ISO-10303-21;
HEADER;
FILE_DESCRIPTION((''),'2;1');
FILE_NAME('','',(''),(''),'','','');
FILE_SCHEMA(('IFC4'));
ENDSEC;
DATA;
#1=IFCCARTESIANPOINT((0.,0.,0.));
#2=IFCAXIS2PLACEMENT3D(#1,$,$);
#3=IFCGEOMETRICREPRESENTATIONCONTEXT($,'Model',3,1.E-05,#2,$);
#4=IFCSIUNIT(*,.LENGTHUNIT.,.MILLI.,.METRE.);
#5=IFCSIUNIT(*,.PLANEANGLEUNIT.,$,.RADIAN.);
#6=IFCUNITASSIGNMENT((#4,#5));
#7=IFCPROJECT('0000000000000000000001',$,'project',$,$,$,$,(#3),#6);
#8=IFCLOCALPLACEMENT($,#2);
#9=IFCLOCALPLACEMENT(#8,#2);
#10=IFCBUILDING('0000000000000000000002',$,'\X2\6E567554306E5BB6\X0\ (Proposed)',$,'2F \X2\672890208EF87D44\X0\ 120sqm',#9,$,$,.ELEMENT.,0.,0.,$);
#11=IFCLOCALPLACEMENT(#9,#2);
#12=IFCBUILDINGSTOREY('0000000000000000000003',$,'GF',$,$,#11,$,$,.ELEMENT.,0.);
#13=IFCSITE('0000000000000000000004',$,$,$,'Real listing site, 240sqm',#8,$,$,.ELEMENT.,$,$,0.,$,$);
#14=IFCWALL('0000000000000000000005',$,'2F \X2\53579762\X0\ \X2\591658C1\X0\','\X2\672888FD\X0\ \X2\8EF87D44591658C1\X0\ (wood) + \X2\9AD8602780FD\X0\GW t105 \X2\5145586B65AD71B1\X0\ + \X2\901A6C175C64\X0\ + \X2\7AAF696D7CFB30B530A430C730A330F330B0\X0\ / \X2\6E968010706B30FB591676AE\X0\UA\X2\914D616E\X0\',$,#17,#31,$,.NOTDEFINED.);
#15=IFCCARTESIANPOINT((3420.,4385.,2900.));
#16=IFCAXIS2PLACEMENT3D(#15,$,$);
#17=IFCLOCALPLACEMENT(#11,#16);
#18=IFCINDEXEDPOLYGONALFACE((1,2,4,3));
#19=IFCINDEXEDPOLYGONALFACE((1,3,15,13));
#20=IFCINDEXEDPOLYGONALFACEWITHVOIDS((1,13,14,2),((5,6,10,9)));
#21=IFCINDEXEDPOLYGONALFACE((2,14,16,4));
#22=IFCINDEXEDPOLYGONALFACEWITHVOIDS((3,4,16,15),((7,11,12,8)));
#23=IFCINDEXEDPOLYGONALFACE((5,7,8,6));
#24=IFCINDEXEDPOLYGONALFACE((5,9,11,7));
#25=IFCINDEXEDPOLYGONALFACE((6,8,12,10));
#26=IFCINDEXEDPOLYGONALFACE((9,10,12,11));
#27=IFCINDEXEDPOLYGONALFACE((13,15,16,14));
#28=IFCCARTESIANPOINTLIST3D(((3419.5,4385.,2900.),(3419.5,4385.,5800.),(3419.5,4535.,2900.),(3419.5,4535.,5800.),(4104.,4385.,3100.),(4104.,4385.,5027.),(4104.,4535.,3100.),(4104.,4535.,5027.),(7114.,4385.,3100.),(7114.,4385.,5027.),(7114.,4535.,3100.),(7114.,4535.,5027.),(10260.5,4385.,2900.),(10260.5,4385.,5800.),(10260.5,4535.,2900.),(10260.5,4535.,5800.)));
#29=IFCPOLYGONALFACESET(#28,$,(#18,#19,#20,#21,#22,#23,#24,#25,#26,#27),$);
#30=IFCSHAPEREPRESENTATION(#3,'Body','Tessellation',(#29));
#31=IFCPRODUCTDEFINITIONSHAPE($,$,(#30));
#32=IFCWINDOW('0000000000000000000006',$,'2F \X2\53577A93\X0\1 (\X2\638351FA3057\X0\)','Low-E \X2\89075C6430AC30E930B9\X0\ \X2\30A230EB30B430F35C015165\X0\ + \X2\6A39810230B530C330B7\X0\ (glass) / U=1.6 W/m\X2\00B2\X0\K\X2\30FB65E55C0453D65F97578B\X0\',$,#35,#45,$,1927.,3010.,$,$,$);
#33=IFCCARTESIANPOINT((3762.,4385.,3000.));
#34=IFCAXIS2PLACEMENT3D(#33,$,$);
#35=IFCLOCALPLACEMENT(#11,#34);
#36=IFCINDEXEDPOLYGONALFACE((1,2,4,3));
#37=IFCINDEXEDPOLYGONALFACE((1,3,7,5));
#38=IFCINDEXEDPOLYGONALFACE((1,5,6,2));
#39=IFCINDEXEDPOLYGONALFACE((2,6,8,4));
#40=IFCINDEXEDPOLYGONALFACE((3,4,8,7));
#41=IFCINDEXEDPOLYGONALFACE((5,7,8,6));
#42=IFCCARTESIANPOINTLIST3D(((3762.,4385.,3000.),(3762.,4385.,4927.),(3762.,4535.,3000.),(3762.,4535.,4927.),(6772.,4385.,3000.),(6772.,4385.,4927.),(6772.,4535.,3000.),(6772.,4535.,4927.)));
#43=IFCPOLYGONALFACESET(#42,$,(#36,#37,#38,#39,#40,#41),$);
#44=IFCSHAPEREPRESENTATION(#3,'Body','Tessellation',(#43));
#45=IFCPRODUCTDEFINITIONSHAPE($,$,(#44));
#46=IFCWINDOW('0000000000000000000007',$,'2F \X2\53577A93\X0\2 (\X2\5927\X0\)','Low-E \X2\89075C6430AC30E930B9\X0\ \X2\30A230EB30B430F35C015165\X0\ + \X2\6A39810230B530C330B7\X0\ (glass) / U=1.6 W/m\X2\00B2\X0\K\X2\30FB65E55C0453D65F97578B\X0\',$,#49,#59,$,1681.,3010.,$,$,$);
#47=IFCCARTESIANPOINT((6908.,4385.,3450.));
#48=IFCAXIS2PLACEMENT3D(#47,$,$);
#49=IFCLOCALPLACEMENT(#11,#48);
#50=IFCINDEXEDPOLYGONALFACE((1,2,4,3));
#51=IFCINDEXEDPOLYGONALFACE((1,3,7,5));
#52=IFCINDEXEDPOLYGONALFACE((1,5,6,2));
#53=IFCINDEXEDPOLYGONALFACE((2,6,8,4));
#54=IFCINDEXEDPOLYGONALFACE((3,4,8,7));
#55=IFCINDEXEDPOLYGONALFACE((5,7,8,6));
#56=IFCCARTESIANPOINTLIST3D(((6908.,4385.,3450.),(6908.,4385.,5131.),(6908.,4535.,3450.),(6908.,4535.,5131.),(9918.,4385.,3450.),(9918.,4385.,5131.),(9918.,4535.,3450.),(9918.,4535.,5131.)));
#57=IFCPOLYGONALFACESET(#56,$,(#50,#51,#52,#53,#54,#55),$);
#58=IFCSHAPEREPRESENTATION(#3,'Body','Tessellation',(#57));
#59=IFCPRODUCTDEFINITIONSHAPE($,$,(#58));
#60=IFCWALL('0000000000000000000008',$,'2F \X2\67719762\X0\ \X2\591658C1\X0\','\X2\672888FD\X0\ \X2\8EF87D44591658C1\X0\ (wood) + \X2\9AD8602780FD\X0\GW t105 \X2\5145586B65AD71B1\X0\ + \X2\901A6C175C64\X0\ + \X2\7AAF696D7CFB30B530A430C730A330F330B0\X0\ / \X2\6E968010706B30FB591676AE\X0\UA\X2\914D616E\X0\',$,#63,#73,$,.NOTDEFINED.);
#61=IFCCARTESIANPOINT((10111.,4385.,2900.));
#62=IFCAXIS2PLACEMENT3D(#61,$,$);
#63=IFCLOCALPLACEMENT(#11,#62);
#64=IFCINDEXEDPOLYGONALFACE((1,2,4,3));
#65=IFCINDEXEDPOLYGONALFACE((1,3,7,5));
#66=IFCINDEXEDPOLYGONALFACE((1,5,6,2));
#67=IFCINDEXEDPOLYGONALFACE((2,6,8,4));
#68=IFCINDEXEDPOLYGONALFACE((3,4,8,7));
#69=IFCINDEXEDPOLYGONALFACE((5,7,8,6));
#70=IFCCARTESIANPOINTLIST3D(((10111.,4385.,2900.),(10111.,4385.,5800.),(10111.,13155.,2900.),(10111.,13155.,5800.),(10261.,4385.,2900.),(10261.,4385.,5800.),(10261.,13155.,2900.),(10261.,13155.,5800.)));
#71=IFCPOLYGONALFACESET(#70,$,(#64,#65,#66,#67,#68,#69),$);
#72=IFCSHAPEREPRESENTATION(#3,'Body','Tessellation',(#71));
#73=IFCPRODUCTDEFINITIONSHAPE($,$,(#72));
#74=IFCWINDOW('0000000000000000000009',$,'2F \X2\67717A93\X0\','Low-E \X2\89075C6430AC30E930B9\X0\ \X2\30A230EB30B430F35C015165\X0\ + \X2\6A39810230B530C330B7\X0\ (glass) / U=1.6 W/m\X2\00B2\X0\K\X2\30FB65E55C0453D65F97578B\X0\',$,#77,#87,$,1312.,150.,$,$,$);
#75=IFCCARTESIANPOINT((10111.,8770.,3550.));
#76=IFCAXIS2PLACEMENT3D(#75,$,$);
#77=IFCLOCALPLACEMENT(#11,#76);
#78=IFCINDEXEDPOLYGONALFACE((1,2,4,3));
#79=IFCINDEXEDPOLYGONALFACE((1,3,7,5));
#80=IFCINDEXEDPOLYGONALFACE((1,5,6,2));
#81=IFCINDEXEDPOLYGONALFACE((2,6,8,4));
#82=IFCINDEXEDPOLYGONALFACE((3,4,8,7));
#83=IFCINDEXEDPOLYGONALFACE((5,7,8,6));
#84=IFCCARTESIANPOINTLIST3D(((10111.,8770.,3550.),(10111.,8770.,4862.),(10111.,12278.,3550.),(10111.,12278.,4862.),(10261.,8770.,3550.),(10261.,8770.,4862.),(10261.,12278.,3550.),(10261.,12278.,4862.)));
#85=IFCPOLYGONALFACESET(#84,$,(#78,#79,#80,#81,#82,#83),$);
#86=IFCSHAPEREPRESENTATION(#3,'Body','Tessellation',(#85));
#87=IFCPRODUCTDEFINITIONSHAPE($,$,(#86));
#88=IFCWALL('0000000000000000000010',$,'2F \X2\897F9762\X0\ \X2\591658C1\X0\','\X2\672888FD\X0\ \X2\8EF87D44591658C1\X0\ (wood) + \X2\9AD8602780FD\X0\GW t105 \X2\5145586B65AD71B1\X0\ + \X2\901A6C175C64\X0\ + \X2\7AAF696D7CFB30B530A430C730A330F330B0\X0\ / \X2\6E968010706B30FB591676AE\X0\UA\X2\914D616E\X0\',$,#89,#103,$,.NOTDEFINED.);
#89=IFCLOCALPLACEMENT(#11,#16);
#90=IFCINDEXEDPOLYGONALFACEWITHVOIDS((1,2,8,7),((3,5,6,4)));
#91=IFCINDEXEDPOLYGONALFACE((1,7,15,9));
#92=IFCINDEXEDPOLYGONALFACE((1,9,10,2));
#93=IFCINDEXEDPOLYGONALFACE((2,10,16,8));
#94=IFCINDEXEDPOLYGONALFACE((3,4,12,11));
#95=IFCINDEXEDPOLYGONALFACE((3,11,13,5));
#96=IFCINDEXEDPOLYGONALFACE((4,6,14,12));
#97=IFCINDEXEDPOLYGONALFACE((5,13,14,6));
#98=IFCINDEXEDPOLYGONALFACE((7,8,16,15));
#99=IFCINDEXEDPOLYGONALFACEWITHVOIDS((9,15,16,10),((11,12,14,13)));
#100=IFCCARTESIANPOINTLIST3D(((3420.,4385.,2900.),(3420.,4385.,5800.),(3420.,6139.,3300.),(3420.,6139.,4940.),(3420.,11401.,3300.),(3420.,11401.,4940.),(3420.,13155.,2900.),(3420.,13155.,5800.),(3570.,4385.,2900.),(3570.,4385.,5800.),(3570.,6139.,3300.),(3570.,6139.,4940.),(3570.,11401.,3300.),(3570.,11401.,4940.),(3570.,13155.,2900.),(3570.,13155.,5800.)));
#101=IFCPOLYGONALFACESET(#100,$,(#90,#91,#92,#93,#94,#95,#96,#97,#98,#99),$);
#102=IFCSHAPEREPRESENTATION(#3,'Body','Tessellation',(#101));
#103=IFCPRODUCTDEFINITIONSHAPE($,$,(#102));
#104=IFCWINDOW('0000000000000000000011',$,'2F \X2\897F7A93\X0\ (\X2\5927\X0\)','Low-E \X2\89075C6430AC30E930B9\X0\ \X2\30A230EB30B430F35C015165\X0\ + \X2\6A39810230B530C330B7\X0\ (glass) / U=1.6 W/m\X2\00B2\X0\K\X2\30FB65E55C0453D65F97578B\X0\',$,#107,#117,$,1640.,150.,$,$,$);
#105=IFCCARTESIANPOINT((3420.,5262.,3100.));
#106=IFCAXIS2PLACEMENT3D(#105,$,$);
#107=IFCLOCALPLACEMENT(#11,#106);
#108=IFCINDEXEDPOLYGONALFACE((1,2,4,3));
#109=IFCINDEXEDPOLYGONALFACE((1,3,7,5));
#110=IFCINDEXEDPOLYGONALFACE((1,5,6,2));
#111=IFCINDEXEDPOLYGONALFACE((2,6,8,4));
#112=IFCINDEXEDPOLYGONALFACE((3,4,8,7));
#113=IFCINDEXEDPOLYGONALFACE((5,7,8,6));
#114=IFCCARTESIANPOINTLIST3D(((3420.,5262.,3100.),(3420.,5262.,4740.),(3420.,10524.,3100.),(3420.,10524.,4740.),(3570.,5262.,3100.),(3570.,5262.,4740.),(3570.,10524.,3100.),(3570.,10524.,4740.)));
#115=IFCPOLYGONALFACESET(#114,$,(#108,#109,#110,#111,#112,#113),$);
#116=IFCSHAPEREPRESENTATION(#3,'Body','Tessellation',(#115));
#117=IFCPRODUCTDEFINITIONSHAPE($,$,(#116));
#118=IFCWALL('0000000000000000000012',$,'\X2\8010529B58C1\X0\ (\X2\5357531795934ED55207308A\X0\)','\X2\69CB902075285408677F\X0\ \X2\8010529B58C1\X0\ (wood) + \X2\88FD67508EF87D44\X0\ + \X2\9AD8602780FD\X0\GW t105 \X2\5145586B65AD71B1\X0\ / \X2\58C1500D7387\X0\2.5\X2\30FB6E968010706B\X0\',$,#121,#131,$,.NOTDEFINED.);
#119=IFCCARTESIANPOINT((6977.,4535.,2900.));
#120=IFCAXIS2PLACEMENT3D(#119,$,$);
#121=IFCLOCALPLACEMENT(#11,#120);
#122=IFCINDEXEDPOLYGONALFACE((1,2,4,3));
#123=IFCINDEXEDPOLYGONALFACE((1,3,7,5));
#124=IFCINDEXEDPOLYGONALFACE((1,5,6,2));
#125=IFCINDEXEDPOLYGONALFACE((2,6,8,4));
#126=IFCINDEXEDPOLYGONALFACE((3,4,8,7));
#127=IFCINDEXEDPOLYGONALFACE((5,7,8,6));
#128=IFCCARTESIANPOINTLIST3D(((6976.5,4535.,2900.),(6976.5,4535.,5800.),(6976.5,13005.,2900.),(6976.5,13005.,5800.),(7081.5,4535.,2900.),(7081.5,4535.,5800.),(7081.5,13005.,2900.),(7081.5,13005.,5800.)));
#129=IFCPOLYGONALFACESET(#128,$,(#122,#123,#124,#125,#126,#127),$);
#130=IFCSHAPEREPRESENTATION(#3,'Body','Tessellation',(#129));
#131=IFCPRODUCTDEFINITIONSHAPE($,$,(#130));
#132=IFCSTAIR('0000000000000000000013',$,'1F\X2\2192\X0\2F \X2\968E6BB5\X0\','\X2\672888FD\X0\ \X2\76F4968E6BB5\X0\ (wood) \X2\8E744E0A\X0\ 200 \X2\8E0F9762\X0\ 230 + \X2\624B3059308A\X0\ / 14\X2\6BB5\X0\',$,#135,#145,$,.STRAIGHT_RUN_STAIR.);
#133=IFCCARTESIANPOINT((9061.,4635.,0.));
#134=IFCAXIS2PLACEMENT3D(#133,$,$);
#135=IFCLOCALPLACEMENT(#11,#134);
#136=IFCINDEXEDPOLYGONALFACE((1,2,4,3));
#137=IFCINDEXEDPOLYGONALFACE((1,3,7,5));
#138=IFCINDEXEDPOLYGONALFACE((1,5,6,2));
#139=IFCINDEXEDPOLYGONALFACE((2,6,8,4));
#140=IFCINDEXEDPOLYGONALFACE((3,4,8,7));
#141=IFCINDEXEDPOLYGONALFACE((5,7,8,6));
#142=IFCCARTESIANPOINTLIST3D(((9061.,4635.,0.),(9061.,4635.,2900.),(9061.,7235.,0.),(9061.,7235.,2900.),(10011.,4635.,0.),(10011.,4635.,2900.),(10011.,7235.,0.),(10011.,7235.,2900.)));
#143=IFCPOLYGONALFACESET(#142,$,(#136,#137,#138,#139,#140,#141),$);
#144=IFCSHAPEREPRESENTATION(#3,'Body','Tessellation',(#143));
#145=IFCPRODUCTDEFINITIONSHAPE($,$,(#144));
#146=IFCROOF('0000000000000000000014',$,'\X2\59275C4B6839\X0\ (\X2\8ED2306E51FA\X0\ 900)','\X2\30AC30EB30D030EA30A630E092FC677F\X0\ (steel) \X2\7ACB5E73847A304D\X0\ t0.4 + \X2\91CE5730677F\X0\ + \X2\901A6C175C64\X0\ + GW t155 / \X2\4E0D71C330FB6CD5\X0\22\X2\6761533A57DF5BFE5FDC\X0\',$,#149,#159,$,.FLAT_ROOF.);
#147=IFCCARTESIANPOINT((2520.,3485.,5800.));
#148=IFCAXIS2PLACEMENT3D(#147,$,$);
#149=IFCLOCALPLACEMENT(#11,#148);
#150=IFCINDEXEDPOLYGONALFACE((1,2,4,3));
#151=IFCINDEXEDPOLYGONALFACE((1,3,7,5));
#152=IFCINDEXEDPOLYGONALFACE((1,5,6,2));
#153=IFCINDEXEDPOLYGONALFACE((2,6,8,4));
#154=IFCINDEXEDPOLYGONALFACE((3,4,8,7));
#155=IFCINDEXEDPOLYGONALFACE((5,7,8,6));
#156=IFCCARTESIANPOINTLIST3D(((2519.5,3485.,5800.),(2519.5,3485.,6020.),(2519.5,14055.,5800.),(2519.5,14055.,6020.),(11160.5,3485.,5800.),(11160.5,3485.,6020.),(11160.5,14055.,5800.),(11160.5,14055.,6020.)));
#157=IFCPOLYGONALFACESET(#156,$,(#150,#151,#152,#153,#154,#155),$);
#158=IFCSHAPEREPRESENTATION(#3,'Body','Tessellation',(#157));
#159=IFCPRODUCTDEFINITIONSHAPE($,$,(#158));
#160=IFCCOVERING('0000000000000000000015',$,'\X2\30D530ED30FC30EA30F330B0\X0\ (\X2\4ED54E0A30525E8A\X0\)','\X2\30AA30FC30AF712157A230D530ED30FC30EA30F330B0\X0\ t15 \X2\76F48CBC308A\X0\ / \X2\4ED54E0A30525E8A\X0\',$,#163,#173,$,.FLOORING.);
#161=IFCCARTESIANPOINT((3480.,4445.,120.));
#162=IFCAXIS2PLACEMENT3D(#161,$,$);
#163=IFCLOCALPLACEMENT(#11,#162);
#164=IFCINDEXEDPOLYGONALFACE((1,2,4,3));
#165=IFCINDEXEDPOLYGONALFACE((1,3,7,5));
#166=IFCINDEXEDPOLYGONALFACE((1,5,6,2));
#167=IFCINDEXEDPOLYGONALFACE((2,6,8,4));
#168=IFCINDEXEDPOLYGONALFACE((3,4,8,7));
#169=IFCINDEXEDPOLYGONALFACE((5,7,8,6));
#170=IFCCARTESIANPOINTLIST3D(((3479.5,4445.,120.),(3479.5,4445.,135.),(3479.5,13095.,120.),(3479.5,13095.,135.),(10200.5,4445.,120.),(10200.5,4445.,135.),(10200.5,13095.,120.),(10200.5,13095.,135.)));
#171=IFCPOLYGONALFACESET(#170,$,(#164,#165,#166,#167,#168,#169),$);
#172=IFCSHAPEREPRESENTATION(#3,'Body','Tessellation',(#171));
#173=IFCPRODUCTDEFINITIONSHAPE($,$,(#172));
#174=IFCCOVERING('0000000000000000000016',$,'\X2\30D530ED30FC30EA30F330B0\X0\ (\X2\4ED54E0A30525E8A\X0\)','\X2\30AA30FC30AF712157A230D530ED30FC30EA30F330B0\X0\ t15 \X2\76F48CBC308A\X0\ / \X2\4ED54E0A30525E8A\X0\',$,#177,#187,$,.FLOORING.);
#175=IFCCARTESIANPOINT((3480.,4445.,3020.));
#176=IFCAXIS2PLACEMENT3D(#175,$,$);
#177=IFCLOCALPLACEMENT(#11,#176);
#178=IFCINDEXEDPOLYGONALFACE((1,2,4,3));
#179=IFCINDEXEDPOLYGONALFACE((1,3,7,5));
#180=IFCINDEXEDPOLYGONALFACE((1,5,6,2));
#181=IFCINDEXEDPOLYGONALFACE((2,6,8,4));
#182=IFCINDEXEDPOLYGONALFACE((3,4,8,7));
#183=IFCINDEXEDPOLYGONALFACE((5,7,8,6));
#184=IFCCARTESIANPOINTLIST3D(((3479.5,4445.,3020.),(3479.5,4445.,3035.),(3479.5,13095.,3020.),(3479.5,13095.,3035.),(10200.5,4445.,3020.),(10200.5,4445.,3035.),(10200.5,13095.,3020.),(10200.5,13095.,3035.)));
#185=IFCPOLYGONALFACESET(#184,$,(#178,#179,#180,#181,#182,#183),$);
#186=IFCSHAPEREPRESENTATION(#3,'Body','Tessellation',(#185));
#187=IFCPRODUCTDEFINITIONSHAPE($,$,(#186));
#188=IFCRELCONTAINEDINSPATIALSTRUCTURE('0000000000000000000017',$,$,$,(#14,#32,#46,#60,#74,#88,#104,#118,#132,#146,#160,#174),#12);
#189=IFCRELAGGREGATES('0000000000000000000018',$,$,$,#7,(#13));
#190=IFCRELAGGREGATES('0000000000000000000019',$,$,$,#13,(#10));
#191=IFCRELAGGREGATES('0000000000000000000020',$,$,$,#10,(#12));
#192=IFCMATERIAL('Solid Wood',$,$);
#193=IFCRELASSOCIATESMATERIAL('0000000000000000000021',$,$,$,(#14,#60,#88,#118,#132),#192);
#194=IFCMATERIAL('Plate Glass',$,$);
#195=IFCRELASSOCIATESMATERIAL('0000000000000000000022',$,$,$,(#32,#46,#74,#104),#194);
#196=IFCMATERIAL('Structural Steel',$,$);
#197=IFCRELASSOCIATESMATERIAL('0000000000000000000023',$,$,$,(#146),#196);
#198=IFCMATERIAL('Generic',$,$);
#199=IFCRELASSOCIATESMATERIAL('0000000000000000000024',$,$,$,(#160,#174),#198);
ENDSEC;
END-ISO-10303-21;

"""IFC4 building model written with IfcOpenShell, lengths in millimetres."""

from ifc_helpers import new_model, si_unit, frame, frame_2d, origin, place, context, project, spatial, rectangle, extrude, material, element, fill, save


model = new_model("IFC4")

# Units and contexts
model_context = context("Model", 3, precision=1e-05, world=origin())
ifc_project = project(units=[si_unit("LENGTHUNIT", "METRE", prefix="MILLI"), si_unit("PLANEANGLEUNIT", "RADIAN")], contexts=[model_context])

# Site, building, storey
site_placement = place(None, origin())
site = spatial("IfcSite", under=ifc_project, at=site_placement, ObjectType="Real listing site, 240sqm", CompositionType="ELEMENT", RefElevation=0.0)
building_placement = place(site_placement, origin())
building = spatial("IfcBuilding", under=site, at=building_placement, Name="湖畔の家 (Proposed)", ObjectType="2F 木造軸組 120sqm", CompositionType="ELEMENT", ElevationOfRefHeight=0.0, ElevationOfTerrain=0.0)
storey_placement = place(building_placement, origin())
storey = spatial("IfcBuildingStorey", under=building, at=storey_placement, Name="GF", CompositionType="ELEMENT", Elevation=0.0)

# Shared definitions
ifc_material_1 = material(Name="Solid Wood")

# Shared definitions
ifc_material_2 = material(Name="Plate Glass")

# Wall, openings, windows
wall_1_placement = place(storey_placement, frame((3420.0, 4385.0, 2900.0)))
wall_1 = element("IfcWall", 1, at=wall_1_placement, inside=storey, material=ifc_material_1, Name="2F 南面 外壁", Description="木製 軸組外壁 (wood) + 高性能GW t105 充填断熱 + 通気層 + 窯業系サイディング / 準耐火・外皮UA配慮", PredefinedType="NOTDEFINED", context=model_context, shape_type="SweptSolid", body=[
    extrude(rectangle(XDim=6841.0, YDim=150.0, at=frame_2d((3420.0, 75.0))), frame((3420.0, 4385.0, 2900.0)), (0.0, 0.0, 1.0), 2900.0),
])
opening_1_placement = place(storey_placement, frame((3762.0, 4385.0, 3000.0)))
opening_1 = element("IfcOpeningElement", 2, at=opening_1_placement, cuts=wall_1, PredefinedType="NOTDEFINED", context=model_context, shape_type="SweptSolid", body=[
    extrude(rectangle(XDim=3010.0, YDim=150.0, at=frame_2d((1505.0, 75.0))), frame((3762.0, 4385.0, 3000.0)), (0.0, 0.0, 1.0), 1927.0),
])
opening_2_placement = place(storey_placement, frame((6908.0, 4385.0, 3450.0)))
opening_2 = element("IfcOpeningElement", 3, at=opening_2_placement, cuts=wall_1, PredefinedType="NOTDEFINED", context=model_context, shape_type="SweptSolid", body=[
    extrude(rectangle(XDim=3010.0, YDim=150.0, at=frame_2d((1505.0, 75.0))), frame((6908.0, 4385.0, 3450.0)), (0.0, 0.0, 1.0), 1681.0),
])
window_1_placement = place(storey_placement, frame((3762.0, 4385.0, 3000.0)))
window_1 = element("IfcWindow", 4, at=window_1_placement, inside=storey, material=ifc_material_2, Name="2F 南窓1 (掃出し)", Description="Low-E 複層ガラス アルゴン封入 + 樹脂サッシ (glass) / U=1.6 W/m²K・日射取得型", OverallHeight=1927.0, OverallWidth=3010.0, context=model_context, shape_type="SweptSolid", body=[
    extrude(rectangle(XDim=3010.0, YDim=150.0, at=frame_2d((1505.0, 75.0))), frame((3762.0, 4385.0, 3000.0)), (0.0, 0.0, 1.0), 1927.0),
])
fill(opening_1, window_1)
window_2_placement = place(storey_placement, frame((6908.0, 4385.0, 3450.0)))
window_2 = element("IfcWindow", 5, at=window_2_placement, inside=storey, material=ifc_material_2, Name="2F 南窓2 (大)", Description="Low-E 複層ガラス アルゴン封入 + 樹脂サッシ (glass) / U=1.6 W/m²K・日射取得型", OverallHeight=1681.0, OverallWidth=3010.0, context=model_context, shape_type="SweptSolid", body=[
    extrude(rectangle(XDim=3010.0, YDim=150.0, at=frame_2d((1505.0, 75.0))), frame((6908.0, 4385.0, 3450.0)), (0.0, 0.0, 1.0), 1681.0),
])
fill(opening_2, window_2)

# Walls, openings, windows
wall_2_placement = place(storey_placement, frame((10111.0, 4385.0, 2900.0)))
wall_2 = element("IfcWall", 6, at=wall_2_placement, inside=storey, material=ifc_material_1, Name="2F 東面 外壁", Description="木製 軸組外壁 (wood) + 高性能GW t105 充填断熱 + 通気層 + 窯業系サイディング / 準耐火・外皮UA配慮", PredefinedType="NOTDEFINED", context=model_context, shape_type="SweptSolid", body=[
    extrude(rectangle(XDim=150.0, YDim=8770.0, at=frame_2d((75.0, 4385.0))), frame((10111.0, 4385.0, 2900.0)), (0.0, 0.0, 1.0), 2900.0),
])
opening_3_placement = place(storey_placement, frame((10111.0, 8770.0, 3550.0)))
opening_3 = element("IfcOpeningElement", 7, at=opening_3_placement, cuts=wall_2, PredefinedType="NOTDEFINED", context=model_context, shape_type="SweptSolid", body=[
    extrude(rectangle(XDim=150.0, YDim=3508.0, at=frame_2d((75.0, 1754.0))), frame((10111.0, 8770.0, 3550.0)), (0.0, 0.0, 1.0), 1312.0),
])
window_3_placement = place(storey_placement, frame((10111.0, 8770.0, 3550.0)))
window_3 = element("IfcWindow", 8, at=window_3_placement, inside=storey, material=ifc_material_2, Name="2F 東窓", Description="Low-E 複層ガラス アルゴン封入 + 樹脂サッシ (glass) / U=1.6 W/m²K・日射取得型", OverallHeight=1312.0, OverallWidth=150.0, context=model_context, shape_type="SweptSolid", body=[
    extrude(rectangle(XDim=150.0, YDim=3508.0, at=frame_2d((75.0, 1754.0))), frame((10111.0, 8770.0, 3550.0)), (0.0, 0.0, 1.0), 1312.0),
])
fill(opening_3, window_3)
wall_3_placement = place(storey_placement, frame((3420.0, 4385.0, 2900.0)))
wall_3 = element("IfcWall", 9, at=wall_3_placement, inside=storey, material=ifc_material_1, Name="2F 西面 外壁", Description="木製 軸組外壁 (wood) + 高性能GW t105 充填断熱 + 通気層 + 窯業系サイディング / 準耐火・外皮UA配慮", PredefinedType="NOTDEFINED", context=model_context, shape_type="SweptSolid", body=[
    extrude(rectangle(XDim=150.0, YDim=8770.0, at=frame_2d((75.0, 4385.0))), frame((3420.0, 4385.0, 2900.0)), (0.0, 0.0, 1.0), 2900.0),
])
opening_4_placement = place(storey_placement, frame((3420.0, 5262.0, 3100.0)))
opening_4 = element("IfcOpeningElement", 10, at=opening_4_placement, cuts=wall_3, PredefinedType="NOTDEFINED", context=model_context, shape_type="SweptSolid", body=[
    extrude(rectangle(XDim=150.0, YDim=5262.0, at=frame_2d((75.0, 2631.0))), frame((3420.0, 5262.0, 3100.0)), (0.0, 0.0, 1.0), 1640.0),
])
window_4_placement = place(storey_placement, frame((3420.0, 5262.0, 3100.0)))
window_4 = element("IfcWindow", 11, at=window_4_placement, inside=storey, material=ifc_material_2, Name="2F 西窓 (大)", Description="Low-E 複層ガラス アルゴン封入 + 樹脂サッシ (glass) / U=1.6 W/m²K・日射取得型", OverallHeight=1640.0, OverallWidth=150.0, context=model_context, shape_type="SweptSolid", body=[
    extrude(rectangle(XDim=150.0, YDim=5262.0, at=frame_2d((75.0, 2631.0))), frame((3420.0, 5262.0, 3100.0)), (0.0, 0.0, 1.0), 1640.0),
])
fill(opening_4, window_4)

# Wall
wall_4_placement = place(storey_placement, frame((6977.0, 4535.0, 2900.0)))
element("IfcWall", 12, at=wall_4_placement, inside=storey, material=ifc_material_1, Name="耐力壁 (南北間仕切り)", Description="構造用合板 耐力壁 (wood) + 製材軸組 + 高性能GW t105 充填断熱 / 壁倍率2.5・準耐火", PredefinedType="NOTDEFINED", context=model_context, shape_type="SweptSolid", body=[
    extrude(rectangle(XDim=105.0, YDim=8470.0, at=frame_2d((52.0, 4235.0))), frame((6977.0, 4535.0, 2900.0)), (0.0, 0.0, 1.0), 2900.0),
])

# Stair
stair_placement = place(storey_placement, frame((9061.0, 4635.0, 0.0)))
element("IfcStair", 13, at=stair_placement, inside=storey, material=ifc_material_1, Name="1F→2F 階段", Description="木製 直階段 (wood) 蹴上 200 踏面 230 + 手すり / 14段", PredefinedType="STRAIGHT_RUN_STAIR", context=model_context, shape_type="SweptSolid", body=[
    extrude(rectangle(XDim=950.0, YDim=2600.0, at=frame_2d((475.0, 1300.0))), frame((9061.0, 4635.0, 0.0)), (0.0, 0.0, 1.0), 2900.0),
])

# Roof
ifc_material_3 = material(Name="Structural Steel")
roof_placement = place(storey_placement, frame((2520.0, 3485.0, 5800.0)))
element("IfcRoof", 14, at=roof_placement, inside=storey, material=ifc_material_3, Name="大屋根 (軒の出 900)", Description="ガルバリウム鋼板 (steel) 立平葺き t0.4 + 野地板 + 通気層 + GW t155 / 不燃・法22条区域対応", PredefinedType="FLAT_ROOF", context=model_context, shape_type="SweptSolid", body=[
    extrude(rectangle(XDim=8641.0, YDim=10570.0, at=frame_2d((4320.0, 5285.0))), frame((2520.0, 3485.0, 5800.0)), (0.0, 0.0, 1.0), 220.0),
])

# Coverings
ifc_material_4 = material(Name="Generic")
covering_1_placement = place(storey_placement, frame((3480.0, 4445.0, 120.0)))
element("IfcCovering", 15, at=covering_1_placement, inside=storey, material=ifc_material_4, Name="フローリング (仕上げ床)", Description="オーク無垢フローリング t15 直貼り / 仕上げ床", PredefinedType="FLOORING", context=model_context, shape_type="SweptSolid", body=[
    extrude(rectangle(XDim=6721.0, YDim=8650.0, at=frame_2d((3360.0, 4325.0))), frame((3480.0, 4445.0, 120.0)), (0.0, 0.0, 1.0), 15.0),
])
covering_2_placement = place(storey_placement, frame((3480.0, 4445.0, 3020.0)))
element("IfcCovering", 16, at=covering_2_placement, inside=storey, material=ifc_material_4, Name="フローリング (仕上げ床)", Description="オーク無垢フローリング t15 直貼り / 仕上げ床", PredefinedType="FLOORING", context=model_context, shape_type="SweptSolid", body=[
    extrude(rectangle(XDim=6721.0, YDim=8650.0, at=frame_2d((3360.0, 4325.0))), frame((3480.0, 4445.0, 3020.0)), (0.0, 0.0, 1.0), 15.0),
])

save(model, "model.ifc")
